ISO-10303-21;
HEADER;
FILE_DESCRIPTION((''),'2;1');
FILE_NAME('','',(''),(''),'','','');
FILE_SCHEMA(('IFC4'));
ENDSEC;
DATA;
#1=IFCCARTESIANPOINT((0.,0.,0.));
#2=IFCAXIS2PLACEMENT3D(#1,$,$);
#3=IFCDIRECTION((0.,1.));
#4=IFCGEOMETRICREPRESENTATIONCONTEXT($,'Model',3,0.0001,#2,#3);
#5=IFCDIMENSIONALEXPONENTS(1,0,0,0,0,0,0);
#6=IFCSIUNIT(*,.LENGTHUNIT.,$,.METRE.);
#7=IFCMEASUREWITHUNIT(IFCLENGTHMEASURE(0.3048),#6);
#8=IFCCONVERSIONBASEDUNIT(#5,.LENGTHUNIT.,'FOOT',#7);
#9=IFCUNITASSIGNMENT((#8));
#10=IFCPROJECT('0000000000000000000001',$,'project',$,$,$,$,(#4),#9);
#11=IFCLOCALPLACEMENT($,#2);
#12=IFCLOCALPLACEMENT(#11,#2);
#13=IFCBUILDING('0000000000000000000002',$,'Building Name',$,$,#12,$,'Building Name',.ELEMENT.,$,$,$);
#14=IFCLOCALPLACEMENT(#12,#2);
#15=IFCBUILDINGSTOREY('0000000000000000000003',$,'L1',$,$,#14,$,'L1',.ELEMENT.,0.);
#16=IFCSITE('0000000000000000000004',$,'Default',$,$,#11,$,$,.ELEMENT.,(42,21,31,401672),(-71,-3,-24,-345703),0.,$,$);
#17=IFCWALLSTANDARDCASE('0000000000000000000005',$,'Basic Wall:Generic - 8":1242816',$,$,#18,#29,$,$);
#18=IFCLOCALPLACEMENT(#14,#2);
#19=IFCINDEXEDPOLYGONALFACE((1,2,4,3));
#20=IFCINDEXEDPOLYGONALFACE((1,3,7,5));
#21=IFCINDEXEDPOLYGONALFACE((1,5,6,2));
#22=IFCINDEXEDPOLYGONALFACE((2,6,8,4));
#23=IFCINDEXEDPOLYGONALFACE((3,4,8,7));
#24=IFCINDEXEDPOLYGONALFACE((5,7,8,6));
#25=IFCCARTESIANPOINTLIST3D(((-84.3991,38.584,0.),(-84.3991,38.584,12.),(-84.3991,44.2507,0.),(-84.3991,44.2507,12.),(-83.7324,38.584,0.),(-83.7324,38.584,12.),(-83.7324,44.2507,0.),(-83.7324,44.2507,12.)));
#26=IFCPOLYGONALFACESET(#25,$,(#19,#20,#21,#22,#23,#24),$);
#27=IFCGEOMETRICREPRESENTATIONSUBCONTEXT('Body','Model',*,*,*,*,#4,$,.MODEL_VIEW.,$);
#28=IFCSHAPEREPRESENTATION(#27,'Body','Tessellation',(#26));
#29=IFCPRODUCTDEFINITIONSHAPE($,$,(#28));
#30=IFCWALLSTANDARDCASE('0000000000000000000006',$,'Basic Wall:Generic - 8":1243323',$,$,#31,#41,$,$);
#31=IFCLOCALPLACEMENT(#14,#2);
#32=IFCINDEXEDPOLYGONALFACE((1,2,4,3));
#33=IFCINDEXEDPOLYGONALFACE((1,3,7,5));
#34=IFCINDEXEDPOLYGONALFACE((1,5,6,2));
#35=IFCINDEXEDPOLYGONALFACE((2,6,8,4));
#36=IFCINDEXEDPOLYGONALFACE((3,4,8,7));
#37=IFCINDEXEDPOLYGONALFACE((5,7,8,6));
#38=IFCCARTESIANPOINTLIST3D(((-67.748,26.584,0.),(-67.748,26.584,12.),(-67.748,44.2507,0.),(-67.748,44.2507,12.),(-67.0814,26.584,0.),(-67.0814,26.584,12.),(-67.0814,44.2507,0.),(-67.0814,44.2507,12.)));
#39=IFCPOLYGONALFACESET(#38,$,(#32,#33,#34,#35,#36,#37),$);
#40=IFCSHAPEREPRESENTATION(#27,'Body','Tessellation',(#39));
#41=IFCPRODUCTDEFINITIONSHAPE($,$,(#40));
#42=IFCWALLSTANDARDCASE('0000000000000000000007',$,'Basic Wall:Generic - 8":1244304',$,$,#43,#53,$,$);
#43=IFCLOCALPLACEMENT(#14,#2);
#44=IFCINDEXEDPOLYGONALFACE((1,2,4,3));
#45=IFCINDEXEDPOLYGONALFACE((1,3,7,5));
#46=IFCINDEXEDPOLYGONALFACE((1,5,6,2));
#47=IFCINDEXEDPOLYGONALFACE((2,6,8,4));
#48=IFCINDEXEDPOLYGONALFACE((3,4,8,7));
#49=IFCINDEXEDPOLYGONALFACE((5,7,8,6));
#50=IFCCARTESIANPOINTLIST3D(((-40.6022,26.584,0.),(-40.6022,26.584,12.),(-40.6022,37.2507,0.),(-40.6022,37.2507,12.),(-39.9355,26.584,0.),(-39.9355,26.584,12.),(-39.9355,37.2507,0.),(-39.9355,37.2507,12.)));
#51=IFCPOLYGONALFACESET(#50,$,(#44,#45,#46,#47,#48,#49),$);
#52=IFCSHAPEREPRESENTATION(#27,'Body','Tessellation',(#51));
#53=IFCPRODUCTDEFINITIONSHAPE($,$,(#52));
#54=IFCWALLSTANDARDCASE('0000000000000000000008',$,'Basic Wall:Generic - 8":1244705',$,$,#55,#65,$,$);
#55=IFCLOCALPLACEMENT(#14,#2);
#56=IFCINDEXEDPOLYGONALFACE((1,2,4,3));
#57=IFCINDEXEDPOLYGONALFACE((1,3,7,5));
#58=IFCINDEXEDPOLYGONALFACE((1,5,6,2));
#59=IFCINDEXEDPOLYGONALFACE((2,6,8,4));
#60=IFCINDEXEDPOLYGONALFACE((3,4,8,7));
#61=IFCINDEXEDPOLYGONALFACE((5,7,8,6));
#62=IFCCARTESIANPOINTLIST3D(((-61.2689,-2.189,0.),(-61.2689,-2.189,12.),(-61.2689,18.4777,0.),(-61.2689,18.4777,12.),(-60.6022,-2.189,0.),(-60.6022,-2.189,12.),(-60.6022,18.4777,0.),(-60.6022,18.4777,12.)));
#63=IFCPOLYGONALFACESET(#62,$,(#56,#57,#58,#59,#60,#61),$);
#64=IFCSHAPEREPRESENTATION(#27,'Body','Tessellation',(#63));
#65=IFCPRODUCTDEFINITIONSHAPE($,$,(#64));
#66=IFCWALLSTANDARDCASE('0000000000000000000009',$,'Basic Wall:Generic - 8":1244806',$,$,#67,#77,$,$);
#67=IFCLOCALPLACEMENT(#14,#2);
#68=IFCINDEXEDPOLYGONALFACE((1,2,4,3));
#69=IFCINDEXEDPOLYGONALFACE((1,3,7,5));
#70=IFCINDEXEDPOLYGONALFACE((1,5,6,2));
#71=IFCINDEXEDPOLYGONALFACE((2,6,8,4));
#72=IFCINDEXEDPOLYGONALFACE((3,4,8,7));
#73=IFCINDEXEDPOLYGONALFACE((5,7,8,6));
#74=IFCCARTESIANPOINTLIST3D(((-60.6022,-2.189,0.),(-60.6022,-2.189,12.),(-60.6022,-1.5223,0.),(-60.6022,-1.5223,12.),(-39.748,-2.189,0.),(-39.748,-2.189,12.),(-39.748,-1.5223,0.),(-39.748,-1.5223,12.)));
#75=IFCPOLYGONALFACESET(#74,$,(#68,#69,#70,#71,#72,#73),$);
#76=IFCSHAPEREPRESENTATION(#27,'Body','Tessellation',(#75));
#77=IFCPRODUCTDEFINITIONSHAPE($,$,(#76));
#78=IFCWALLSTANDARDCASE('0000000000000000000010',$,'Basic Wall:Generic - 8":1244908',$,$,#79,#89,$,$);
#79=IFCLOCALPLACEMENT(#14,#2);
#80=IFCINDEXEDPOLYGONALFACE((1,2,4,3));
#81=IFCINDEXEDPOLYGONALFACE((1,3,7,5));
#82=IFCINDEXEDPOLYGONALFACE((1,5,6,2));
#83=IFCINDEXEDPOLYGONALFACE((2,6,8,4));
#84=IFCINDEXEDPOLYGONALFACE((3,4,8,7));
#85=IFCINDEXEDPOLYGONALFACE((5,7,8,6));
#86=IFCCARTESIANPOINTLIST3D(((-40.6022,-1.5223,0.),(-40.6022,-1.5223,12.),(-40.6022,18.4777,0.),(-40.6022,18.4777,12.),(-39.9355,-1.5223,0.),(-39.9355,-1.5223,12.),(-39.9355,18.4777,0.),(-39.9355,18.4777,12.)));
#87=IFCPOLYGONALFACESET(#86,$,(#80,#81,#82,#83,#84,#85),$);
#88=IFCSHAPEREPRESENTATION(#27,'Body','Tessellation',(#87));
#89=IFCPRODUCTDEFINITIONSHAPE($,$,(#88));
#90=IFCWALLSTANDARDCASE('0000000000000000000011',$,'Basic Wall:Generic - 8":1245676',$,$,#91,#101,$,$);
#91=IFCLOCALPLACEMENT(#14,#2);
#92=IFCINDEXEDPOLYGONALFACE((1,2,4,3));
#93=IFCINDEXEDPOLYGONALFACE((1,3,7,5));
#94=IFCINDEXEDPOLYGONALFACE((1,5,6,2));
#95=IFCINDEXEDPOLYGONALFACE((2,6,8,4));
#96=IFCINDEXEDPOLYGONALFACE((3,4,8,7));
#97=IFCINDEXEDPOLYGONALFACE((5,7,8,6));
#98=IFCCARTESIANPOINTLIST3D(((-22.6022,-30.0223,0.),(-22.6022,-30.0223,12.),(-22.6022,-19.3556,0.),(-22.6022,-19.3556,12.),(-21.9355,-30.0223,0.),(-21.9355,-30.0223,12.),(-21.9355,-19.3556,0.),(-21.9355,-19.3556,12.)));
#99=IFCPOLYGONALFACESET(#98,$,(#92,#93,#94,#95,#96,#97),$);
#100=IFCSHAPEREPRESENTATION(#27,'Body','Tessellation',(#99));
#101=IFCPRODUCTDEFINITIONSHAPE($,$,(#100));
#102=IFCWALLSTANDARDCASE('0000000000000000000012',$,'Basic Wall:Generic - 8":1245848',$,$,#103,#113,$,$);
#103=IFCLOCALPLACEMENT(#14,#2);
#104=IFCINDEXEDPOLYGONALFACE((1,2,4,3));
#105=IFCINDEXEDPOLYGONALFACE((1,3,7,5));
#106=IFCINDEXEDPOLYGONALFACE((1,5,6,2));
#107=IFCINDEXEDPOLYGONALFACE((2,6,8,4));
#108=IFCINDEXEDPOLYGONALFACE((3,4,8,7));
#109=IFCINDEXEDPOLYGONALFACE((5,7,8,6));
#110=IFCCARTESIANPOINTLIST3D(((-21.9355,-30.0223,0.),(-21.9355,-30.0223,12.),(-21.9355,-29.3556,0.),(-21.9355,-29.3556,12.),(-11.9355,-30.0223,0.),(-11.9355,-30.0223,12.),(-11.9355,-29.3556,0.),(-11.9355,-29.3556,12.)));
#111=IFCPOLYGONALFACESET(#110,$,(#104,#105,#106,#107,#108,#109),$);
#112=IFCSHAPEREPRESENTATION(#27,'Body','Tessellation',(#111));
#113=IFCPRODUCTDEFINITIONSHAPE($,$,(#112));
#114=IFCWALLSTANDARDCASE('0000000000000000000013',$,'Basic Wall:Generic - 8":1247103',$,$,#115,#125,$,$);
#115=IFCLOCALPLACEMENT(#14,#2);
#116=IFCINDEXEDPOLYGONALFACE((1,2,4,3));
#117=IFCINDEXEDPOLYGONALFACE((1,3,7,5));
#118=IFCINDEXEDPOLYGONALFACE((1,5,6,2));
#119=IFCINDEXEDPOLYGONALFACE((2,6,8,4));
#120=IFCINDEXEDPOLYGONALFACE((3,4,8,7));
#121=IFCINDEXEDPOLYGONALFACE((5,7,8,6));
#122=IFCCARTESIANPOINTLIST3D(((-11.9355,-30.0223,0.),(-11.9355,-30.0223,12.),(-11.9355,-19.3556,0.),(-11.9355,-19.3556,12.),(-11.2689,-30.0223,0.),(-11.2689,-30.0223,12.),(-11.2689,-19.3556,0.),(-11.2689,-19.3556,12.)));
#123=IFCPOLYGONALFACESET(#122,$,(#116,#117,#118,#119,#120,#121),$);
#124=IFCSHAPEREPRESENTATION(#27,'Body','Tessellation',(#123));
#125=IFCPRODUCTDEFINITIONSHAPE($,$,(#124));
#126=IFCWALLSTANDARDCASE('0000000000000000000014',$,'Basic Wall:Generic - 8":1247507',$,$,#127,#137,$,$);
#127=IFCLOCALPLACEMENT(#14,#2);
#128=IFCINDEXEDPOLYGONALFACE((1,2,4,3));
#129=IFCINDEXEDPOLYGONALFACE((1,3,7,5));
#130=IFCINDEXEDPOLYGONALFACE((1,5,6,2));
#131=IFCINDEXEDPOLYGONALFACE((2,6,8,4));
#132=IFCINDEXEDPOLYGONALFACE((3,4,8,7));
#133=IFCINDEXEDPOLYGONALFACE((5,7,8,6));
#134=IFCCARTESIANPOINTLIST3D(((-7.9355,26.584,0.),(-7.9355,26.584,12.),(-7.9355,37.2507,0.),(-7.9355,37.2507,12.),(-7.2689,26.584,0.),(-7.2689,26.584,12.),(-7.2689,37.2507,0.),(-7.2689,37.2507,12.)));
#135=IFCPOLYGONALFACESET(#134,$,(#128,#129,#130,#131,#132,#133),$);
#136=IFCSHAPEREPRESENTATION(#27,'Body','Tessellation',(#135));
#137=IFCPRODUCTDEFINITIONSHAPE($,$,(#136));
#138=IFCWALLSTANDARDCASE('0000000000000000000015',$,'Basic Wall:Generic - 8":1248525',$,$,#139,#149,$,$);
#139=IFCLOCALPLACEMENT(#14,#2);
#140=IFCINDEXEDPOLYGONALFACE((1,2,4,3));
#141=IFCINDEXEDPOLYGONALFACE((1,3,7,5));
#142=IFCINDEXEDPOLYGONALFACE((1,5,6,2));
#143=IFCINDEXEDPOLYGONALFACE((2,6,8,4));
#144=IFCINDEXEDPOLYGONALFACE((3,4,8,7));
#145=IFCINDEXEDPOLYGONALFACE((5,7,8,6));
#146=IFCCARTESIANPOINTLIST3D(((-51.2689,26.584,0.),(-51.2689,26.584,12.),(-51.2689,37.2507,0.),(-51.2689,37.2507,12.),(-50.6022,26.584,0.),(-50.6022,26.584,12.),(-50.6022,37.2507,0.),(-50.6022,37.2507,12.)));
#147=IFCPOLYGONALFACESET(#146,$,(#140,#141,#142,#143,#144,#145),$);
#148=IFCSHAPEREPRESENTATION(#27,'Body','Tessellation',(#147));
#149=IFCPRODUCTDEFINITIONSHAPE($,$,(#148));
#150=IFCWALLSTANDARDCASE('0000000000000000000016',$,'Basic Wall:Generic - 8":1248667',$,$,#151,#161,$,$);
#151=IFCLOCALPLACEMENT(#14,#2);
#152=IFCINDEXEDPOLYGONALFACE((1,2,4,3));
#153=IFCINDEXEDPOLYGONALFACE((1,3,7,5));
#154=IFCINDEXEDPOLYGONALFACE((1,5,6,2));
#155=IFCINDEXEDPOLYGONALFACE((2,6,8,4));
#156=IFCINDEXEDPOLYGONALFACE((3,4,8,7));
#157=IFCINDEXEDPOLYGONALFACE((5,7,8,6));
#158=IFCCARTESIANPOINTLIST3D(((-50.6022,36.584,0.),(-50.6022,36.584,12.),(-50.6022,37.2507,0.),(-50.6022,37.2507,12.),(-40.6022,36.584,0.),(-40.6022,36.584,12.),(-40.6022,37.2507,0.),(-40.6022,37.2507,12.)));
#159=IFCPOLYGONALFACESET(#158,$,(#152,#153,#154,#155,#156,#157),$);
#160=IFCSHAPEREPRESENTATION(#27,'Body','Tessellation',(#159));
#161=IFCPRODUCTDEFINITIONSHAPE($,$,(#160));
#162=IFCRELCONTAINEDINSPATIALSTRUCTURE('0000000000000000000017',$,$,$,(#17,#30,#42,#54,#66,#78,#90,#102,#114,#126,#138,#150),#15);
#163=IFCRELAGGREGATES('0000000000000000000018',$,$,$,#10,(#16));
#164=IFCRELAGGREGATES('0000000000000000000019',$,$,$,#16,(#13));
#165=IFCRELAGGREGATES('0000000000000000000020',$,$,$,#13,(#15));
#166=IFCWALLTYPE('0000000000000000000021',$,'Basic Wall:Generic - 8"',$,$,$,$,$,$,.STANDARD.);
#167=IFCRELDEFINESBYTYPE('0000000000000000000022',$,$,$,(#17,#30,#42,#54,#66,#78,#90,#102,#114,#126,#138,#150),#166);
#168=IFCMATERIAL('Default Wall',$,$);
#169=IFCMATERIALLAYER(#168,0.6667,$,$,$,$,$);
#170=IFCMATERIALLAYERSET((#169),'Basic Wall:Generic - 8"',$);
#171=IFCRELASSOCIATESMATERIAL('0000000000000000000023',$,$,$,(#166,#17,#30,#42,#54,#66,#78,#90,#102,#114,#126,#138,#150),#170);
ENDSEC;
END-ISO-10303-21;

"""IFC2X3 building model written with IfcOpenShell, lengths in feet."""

from ifc_helpers import new_model, entity, si_unit, converted_unit, direction, frame, frame_2d, origin, place, context, subcontext, project, spatial, rectangle, extrude, material, layer, layer_set, layer_usage, type_object, element, save


model = new_model("IFC2X3")

# Units and contexts
model_context = context("Model", 3, precision=0.0001, world=origin(), true_north=direction((0.0, 1.0)))
body_context = subcontext(model_context, "Body", "Model", "MODEL_VIEW")
ifc_project = project(units=[converted_unit("LENGTHUNIT", "FOOT", entity("IfcLengthMeasure", 0.3048), si_unit("LENGTHUNIT", "METRE"), dimensions=[1, 0, 0, 0, 0, 0, 0])], contexts=[model_context])

# Site, building, storey
site_placement = place(None, origin())
site = spatial("IfcSite", under=ifc_project, at=site_placement, Name="Default", CompositionType="ELEMENT", RefLatitude=(42, 21, 31, 401672), RefLongitude=(-71, -3, -24, -345703), RefElevation=0.0)
building_placement = place(site_placement, origin())
building = spatial("IfcBuilding", under=site, at=building_placement, Name="Building Name", LongName="Building Name", CompositionType="ELEMENT")
storey_placement = place(building_placement, origin())
storey = spatial("IfcBuildingStorey", under=building, at=storey_placement, Name="L1", LongName="L1", CompositionType="ELEMENT", Elevation=0.0)

# Walls
ifc_material_1 = material(Name="Default Wall")
ifc_layer_1 = layer(ifc_material_1, 0.6667)
ifc_layer_set_1 = layer_set([ifc_layer_1], Name="Basic Wall:Generic - 8\"")
wall_type_1 = type_object("IfcWallType", Name="Basic Wall:Generic - 8\"", PredefinedType="STANDARD", material=ifc_layer_set_1)
ifc_layer_usage_1 = layer_usage(ifc_layer_set_1, "AXIS2", "NEGATIVE", 0.3333)
wall_1_placement = place(storey_placement, frame((-84.0657, 44.2507, 0.0), z_axis=(0.0, 0.0, 1.0), x_axis=(0.0, -1.0, 0.0)))
element("IfcWallStandardCase", 1, at=wall_1_placement, inside=storey, type_object=wall_type_1, material=ifc_layer_usage_1, Name="Basic Wall:Generic - 8\":1242816", context=body_context, shape_type="SweptSolid", body=[
    extrude(rectangle(XDim=5.6667, YDim=0.6667, at=frame_2d((2.8333, 0.0), x_axis=(-1.0, 0.0))), origin(), (0.0, 0.0, 1.0), 12.0),
])
ifc_layer_usage_2 = layer_usage(ifc_layer_set_1, "AXIS2", "NEGATIVE", 0.3333)
wall_2_placement = place(storey_placement, frame((-67.4147, 44.2507, 0.0), z_axis=(0.0, 0.0, 1.0), x_axis=(0.0, -1.0, 0.0)))
element("IfcWallStandardCase", 2, at=wall_2_placement, inside=storey, type_object=wall_type_1, material=ifc_layer_usage_2, Name="Basic Wall:Generic - 8\":1243323", context=body_context, shape_type="SweptSolid", body=[
    extrude(rectangle(XDim=17.6667, YDim=0.6667, at=frame_2d((8.8333, 0.0), x_axis=(-1.0, 0.0))), origin(), (0.0, 0.0, 1.0), 12.0),
])
ifc_layer_usage_3 = layer_usage(ifc_layer_set_1, "AXIS2", "NEGATIVE", 0.3333)
wall_3_placement = place(storey_placement, frame((-40.2689, 26.584, 0.0), z_axis=(0.0, 0.0, 1.0), x_axis=(0.0, 1.0, 0.0)))
element("IfcWallStandardCase", 3, at=wall_3_placement, inside=storey, type_object=wall_type_1, material=ifc_layer_usage_3, Name="Basic Wall:Generic - 8\":1244304", context=body_context, shape_type="SweptSolid", body=[
    extrude(rectangle(XDim=10.6667, YDim=0.6667, at=frame_2d((5.3333, 0.0), x_axis=(-1.0, 0.0))), origin(), (0.0, 0.0, 1.0), 12.0),
])
ifc_layer_usage_4 = layer_usage(ifc_layer_set_1, "AXIS2", "NEGATIVE", 0.3333)
wall_4_placement = place(storey_placement, frame((-60.9355, 18.4777, 0.0), z_axis=(0.0, 0.0, 1.0), x_axis=(0.0, -1.0, 0.0)))
element("IfcWallStandardCase", 4, at=wall_4_placement, inside=storey, type_object=wall_type_1, material=ifc_layer_usage_4, Name="Basic Wall:Generic - 8\":1244705", context=body_context, shape_type="SweptSolid", body=[
    extrude(rectangle(XDim=20.6667, YDim=0.6667, at=frame_2d((10.3333, 0.0), x_axis=(-1.0, 0.0))), origin(), (0.0, 0.0, 1.0), 12.0),
])
ifc_layer_usage_5 = layer_usage(ifc_layer_set_1, "AXIS2", "NEGATIVE", 0.3333)
wall_5_placement = place(storey_placement, frame((-60.6022, -1.8556, 0.0)))
element("IfcWallStandardCase", 5, at=wall_5_placement, inside=storey, type_object=wall_type_1, material=ifc_layer_usage_5, Name="Basic Wall:Generic - 8\":1244806", context=body_context, shape_type="SweptSolid", body=[
    extrude(rectangle(XDim=20.8542, YDim=0.6667, at=frame_2d((10.4271, 0.0), x_axis=(-1.0, 0.0))), origin(), (0.0, 0.0, 1.0), 12.0),
])
ifc_layer_usage_6 = layer_usage(ifc_layer_set_1, "AXIS2", "POSITIVE", -0.3333)
wall_6_placement = place(storey_placement, frame((-40.2689, 18.4777, 0.0), z_axis=(0.0, 0.0, 1.0), x_axis=(0.0, -1.0, 0.0)))
element("IfcWallStandardCase", 6, at=wall_6_placement, inside=storey, type_object=wall_type_1, material=ifc_layer_usage_6, Name="Basic Wall:Generic - 8\":1244908", context=body_context, shape_type="SweptSolid", body=[
    extrude(rectangle(XDim=20.0, YDim=0.6667, at=frame_2d((10.0, 0.0), x_axis=(-1.0, 0.0))), origin(), (0.0, 0.0, 1.0), 12.0),
])
ifc_layer_usage_7 = layer_usage(ifc_layer_set_1, "AXIS2", "POSITIVE", -0.3333)
wall_7_placement = place(storey_placement, frame((-22.2689, -19.3556, 0.0), z_axis=(0.0, 0.0, 1.0), x_axis=(0.0, -1.0, 0.0)))
element("IfcWallStandardCase", 7, at=wall_7_placement, inside=storey, type_object=wall_type_1, material=ifc_layer_usage_7, Name="Basic Wall:Generic - 8\":1245676", context=body_context, shape_type="SweptSolid", body=[
    extrude(rectangle(XDim=10.6667, YDim=0.6667, at=frame_2d((5.3333, 0.0), x_axis=(-1.0, 0.0))), origin(), (0.0, 0.0, 1.0), 12.0),
])
ifc_layer_usage_8 = layer_usage(ifc_layer_set_1, "AXIS2", "POSITIVE", -0.3333)
wall_8_placement = place(storey_placement, frame((-21.9355, -29.689, 0.0)))
element("IfcWallStandardCase", 8, at=wall_8_placement, inside=storey, type_object=wall_type_1, material=ifc_layer_usage_8, Name="Basic Wall:Generic - 8\":1245848", context=body_context, shape_type="SweptSolid", body=[
    extrude(rectangle(XDim=10.0, YDim=0.6667, at=frame_2d((5.0, 0.0), x_axis=(-1.0, 0.0))), origin(), (0.0, 0.0, 1.0), 12.0),
])
ifc_layer_usage_9 = layer_usage(ifc_layer_set_1, "AXIS2", "NEGATIVE", 0.3333)
wall_9_placement = place(storey_placement, frame((-11.6022, -19.3556, 0.0), z_axis=(0.0, 0.0, 1.0), x_axis=(0.0, -1.0, 0.0)))
element("IfcWallStandardCase", 9, at=wall_9_placement, inside=storey, type_object=wall_type_1, material=ifc_layer_usage_9, Name="Basic Wall:Generic - 8\":1247103", context=body_context, shape_type="SweptSolid", body=[
    extrude(rectangle(XDim=10.6667, YDim=0.6667, at=frame_2d((5.3333, 0.0), x_axis=(-1.0, 0.0))), origin(), (0.0, 0.0, 1.0), 12.0),
])
ifc_layer_usage_10 = layer_usage(ifc_layer_set_1, "AXIS2", "POSITIVE", -0.3333)
wall_10_placement = place(storey_placement, frame((-7.6022, 37.2507, 0.0), z_axis=(0.0, 0.0, 1.0), x_axis=(0.0, -1.0, 0.0)))
element("IfcWallStandardCase", 10, at=wall_10_placement, inside=storey, type_object=wall_type_1, material=ifc_layer_usage_10, Name="Basic Wall:Generic - 8\":1247507", context=body_context, shape_type="SweptSolid", body=[
    extrude(rectangle(XDim=10.6667, YDim=0.6667, at=frame_2d((5.3333, 0.0), x_axis=(-1.0, 0.0))), origin(), (0.0, 0.0, 1.0), 12.0),
])
ifc_layer_usage_11 = layer_usage(ifc_layer_set_1, "AXIS2", "NEGATIVE", 0.3333)
wall_11_placement = place(storey_placement, frame((-50.9355, 26.584, 0.0), z_axis=(0.0, 0.0, 1.0), x_axis=(0.0, 1.0, 0.0)))
element("IfcWallStandardCase", 11, at=wall_11_placement, inside=storey, type_object=wall_type_1, material=ifc_layer_usage_11, Name="Basic Wall:Generic - 8\":1248525", context=body_context, shape_type="SweptSolid", body=[
    extrude(rectangle(XDim=10.6667, YDim=0.6667, at=frame_2d((5.3333, 0.0), x_axis=(-1.0, 0.0))), origin(), (0.0, 0.0, 1.0), 12.0),
])
ifc_layer_usage_12 = layer_usage(ifc_layer_set_1, "AXIS2", "POSITIVE", -0.3333)
wall_12_placement = place(storey_placement, frame((-50.6022, 36.9174, 0.0)))
element("IfcWallStandardCase", 12, at=wall_12_placement, inside=storey, type_object=wall_type_1, material=ifc_layer_usage_12, Name="Basic Wall:Generic - 8\":1248667", context=body_context, shape_type="SweptSolid", body=[
    extrude(rectangle(XDim=10.0, YDim=0.6667, at=frame_2d((5.0, 0.0), x_axis=(-1.0, 0.0))), origin(), (0.0, 0.0, 1.0), 12.0),
])

save(model, "model.ifc")
